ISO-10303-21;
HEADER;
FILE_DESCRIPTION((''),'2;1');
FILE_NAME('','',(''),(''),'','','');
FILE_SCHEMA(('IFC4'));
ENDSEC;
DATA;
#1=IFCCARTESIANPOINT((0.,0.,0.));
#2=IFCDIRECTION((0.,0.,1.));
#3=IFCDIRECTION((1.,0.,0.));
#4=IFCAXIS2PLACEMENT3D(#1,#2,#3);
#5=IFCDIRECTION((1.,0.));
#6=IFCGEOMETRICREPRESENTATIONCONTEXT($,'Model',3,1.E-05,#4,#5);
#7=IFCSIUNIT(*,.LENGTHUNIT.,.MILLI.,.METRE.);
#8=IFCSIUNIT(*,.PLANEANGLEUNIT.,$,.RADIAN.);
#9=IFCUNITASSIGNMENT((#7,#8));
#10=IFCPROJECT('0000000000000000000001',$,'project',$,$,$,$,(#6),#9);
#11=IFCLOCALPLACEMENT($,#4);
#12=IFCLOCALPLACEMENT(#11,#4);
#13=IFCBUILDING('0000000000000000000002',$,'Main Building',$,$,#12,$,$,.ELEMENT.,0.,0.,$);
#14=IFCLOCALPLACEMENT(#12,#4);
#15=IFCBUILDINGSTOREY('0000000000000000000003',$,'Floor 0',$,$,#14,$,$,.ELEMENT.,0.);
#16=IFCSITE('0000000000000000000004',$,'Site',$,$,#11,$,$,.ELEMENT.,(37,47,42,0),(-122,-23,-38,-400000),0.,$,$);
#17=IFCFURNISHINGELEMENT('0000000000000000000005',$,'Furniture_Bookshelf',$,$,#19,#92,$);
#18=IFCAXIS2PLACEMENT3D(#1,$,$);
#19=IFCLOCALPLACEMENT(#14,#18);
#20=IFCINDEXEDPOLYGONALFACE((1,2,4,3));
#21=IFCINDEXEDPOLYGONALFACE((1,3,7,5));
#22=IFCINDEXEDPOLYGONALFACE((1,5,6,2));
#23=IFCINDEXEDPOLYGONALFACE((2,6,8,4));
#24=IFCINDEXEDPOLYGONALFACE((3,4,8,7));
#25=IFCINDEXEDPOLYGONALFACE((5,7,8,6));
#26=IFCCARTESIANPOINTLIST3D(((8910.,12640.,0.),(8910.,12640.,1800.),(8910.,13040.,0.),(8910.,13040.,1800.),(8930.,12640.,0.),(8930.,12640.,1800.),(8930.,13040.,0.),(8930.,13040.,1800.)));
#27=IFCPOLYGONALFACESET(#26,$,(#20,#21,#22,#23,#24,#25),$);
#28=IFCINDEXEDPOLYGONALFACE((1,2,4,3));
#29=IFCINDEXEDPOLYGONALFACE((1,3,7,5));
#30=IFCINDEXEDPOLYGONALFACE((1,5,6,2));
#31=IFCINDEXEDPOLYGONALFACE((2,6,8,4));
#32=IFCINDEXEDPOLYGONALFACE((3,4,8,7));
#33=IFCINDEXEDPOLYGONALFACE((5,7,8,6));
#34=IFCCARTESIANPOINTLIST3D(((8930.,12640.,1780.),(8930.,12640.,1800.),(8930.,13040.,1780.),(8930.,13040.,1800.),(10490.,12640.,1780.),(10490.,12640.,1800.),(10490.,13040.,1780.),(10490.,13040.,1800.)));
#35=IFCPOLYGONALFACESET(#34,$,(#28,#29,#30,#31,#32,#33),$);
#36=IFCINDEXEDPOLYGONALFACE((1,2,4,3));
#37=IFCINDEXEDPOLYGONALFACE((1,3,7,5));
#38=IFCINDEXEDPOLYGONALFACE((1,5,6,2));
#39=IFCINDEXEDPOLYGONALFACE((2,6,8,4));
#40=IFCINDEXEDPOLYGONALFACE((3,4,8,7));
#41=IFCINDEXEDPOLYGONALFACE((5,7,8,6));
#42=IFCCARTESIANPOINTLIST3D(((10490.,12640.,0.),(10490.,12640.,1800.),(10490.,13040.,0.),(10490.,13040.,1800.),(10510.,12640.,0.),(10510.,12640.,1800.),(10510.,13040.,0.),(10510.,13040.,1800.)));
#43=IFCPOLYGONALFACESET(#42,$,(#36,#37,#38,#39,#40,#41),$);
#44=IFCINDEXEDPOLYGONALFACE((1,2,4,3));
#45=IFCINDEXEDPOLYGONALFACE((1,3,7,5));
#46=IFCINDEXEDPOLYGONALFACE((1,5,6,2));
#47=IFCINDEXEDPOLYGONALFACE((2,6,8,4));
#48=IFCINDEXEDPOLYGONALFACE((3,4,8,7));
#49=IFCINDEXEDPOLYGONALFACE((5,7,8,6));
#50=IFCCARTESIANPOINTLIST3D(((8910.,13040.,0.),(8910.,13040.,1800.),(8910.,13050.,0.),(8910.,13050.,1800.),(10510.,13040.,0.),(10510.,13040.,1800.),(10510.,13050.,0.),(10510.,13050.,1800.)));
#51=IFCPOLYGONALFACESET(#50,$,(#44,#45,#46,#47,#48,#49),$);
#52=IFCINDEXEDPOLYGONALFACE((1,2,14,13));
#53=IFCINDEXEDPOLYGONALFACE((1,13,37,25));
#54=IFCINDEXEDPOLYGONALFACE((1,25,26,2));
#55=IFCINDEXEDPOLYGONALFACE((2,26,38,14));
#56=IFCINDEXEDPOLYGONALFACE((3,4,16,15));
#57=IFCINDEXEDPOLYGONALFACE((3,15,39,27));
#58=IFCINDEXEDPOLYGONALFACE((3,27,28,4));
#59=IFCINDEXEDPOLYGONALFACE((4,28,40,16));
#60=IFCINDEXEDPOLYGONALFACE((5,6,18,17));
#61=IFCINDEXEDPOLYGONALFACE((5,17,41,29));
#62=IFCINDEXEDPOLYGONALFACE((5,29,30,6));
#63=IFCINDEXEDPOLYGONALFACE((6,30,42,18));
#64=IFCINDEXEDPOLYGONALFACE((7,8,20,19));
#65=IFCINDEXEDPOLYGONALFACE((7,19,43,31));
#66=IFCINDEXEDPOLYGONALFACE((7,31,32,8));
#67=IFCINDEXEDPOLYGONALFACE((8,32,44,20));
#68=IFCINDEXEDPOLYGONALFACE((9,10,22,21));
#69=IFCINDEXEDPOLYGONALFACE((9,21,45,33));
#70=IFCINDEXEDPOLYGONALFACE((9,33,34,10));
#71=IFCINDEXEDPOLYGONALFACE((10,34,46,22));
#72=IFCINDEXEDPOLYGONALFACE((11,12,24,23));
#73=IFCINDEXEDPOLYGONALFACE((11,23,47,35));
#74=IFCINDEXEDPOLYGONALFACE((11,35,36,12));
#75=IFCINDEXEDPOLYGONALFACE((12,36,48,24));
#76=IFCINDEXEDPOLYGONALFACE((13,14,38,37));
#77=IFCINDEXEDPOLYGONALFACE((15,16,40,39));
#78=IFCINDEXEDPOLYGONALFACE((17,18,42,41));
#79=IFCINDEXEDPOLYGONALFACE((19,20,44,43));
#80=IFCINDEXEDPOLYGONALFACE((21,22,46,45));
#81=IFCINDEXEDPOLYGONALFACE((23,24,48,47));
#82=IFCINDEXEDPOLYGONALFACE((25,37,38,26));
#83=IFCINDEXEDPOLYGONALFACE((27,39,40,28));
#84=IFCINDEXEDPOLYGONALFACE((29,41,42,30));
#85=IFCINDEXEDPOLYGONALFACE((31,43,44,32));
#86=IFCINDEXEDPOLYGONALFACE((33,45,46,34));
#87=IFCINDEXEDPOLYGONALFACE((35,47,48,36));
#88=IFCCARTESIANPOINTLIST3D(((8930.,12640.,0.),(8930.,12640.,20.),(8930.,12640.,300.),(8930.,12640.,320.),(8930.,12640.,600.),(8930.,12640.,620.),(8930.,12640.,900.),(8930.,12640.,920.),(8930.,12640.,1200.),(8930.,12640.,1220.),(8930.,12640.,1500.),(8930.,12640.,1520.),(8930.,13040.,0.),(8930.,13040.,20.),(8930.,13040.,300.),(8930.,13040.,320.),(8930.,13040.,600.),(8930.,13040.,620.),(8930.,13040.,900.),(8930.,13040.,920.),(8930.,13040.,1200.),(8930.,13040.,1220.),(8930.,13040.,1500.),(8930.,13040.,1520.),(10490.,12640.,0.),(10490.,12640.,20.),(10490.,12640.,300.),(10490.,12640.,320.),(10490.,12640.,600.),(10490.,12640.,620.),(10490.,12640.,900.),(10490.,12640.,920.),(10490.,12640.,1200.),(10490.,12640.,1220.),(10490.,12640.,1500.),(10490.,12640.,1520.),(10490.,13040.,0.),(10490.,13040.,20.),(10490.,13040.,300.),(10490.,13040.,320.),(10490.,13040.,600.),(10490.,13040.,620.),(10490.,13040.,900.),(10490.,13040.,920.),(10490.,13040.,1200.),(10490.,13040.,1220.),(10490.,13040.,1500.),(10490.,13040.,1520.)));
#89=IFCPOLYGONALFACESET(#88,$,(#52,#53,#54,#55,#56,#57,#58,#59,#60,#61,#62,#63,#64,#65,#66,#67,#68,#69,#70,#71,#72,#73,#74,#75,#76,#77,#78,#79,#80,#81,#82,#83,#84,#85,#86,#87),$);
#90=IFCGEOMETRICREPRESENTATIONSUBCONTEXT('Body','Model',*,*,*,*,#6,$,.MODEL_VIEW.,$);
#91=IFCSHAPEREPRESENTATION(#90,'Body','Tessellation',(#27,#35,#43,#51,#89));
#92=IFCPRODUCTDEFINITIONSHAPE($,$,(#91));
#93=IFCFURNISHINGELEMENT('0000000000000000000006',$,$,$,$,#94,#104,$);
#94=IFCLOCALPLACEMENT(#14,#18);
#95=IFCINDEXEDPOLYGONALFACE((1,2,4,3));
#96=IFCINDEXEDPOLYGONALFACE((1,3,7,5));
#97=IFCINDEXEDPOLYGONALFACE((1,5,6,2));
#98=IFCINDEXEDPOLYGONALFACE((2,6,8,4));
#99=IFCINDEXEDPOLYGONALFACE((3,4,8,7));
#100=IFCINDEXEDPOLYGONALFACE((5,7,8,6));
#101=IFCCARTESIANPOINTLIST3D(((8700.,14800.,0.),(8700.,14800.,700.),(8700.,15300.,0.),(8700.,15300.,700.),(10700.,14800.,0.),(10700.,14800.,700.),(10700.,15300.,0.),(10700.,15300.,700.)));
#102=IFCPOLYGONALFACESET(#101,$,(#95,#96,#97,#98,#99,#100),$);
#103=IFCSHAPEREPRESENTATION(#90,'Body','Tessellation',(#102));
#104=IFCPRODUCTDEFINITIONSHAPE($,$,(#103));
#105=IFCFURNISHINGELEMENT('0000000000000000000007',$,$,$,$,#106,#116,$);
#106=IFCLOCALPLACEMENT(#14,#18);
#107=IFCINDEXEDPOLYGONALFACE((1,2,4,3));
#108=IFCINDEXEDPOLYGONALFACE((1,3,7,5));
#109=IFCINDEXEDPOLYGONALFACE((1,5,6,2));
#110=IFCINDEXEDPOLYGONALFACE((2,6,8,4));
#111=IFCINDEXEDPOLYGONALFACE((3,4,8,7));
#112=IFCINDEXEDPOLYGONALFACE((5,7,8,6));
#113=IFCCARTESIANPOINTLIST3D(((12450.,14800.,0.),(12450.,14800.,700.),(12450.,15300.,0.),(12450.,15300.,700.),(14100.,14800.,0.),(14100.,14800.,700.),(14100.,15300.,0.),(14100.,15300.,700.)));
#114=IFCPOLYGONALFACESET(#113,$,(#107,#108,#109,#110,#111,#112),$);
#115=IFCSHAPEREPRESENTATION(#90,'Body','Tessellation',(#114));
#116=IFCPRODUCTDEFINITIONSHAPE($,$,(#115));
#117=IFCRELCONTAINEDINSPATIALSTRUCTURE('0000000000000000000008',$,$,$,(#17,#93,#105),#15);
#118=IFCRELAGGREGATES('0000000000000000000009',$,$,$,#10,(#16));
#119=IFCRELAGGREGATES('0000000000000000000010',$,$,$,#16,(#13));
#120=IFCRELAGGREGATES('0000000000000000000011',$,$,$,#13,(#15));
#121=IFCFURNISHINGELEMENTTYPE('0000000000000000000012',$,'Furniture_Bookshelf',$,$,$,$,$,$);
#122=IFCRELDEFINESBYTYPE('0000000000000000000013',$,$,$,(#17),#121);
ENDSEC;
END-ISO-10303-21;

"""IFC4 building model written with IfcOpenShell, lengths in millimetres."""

from ifc_helpers import new_model, si_unit, direction, frame, frame_2d, origin_with_axes, origin_2d_with_axis, place, context, subcontext, project, spatial, rectangle, extrude, source, transform, mapped, type_object, type_shapes, element, save


model = new_model("IFC4")

# Units and contexts
model_context = context("Model", 3, precision=1e-05, world=origin_with_axes(), true_north=direction((1.0, 0.0)))
body_context = subcontext(model_context, "Body", "Model", "MODEL_VIEW")
ifc_project = project(units=[si_unit("LENGTHUNIT", "METRE", prefix="MILLI"), si_unit("PLANEANGLEUNIT", "RADIAN")], contexts=[model_context])

# Site, building, storey
site_placement = place(None, origin_with_axes())
site = spatial("IfcSite", under=ifc_project, at=site_placement, Name="Site", CompositionType="ELEMENT", RefLatitude=(37, 47, 42, 0), RefLongitude=(-122, -23, -38, -400000), RefElevation=0.0)
building_placement = place(site_placement, origin_with_axes())
building = spatial("IfcBuilding", under=site, at=building_placement, Name="Main Building", CompositionType="ELEMENT", ElevationOfRefHeight=0.0, ElevationOfTerrain=0.0)
storey_placement = place(building_placement, origin_with_axes())
storey = spatial("IfcBuildingStorey", under=building, at=storey_placement, Name="Floor 0", CompositionType="ELEMENT", Elevation=0.0)

# Furnishing elements
furnishing_element_type_1 = type_object("IfcFurnishingElementType", Name="Furniture_Bookshelf")
shared_shape_1 = source(origin_with_axes(), body_context, "Body", "SweptSolid", [
    extrude(rectangle(XDim=400.0, YDim=20.0, at=frame_2d((0.0, 0.0), x_axis=(0.0, 1.0))), frame((10.0, 200.0, 0.0), z_axis=(0.0, 0.0, 1.0), x_axis=(1.0, 0.0, 0.0)), (0.0, 0.0, 1.0), 1800.0),
])
shared_shape_2 = source(origin_with_axes(), body_context, "Body", "SweptSolid", [
    extrude(rectangle(XDim=1560.0, YDim=400.0, at=origin_2d_with_axis()), frame((800.0, 200.0, 1780.0), z_axis=(0.0, 0.0, 1.0), x_axis=(1.0, 0.0, 0.0)), (0.0, 0.0, 1.0), 20.0),
])
shared_shape_3 = source(origin_with_axes(), body_context, "Body", "SweptSolid", [
    extrude(rectangle(XDim=400.0, YDim=20.0, at=frame_2d((0.0, 0.0), x_axis=(0.0, 1.0))), frame((1590.0, 200.0, 0.0), z_axis=(0.0, 0.0, 1.0), x_axis=(1.0, 0.0, 0.0)), (0.0, 0.0, 1.0), 1800.0),
])
shared_shape_4 = source(origin_with_axes(), body_context, "Body", "SweptSolid", [
    extrude(rectangle(XDim=1600.0, YDim=10.0, at=origin_2d_with_axis()), frame((800.0, 405.0, 0.0), z_axis=(0.0, 0.0, 1.0), x_axis=(1.0, 0.0, 0.0)), (0.0, 0.0, 1.0), 1800.0),
])
shared_shape_5 = source(origin_with_axes(), body_context, "Body", "SweptSolid", [
    extrude(rectangle(XDim=1560.0, YDim=400.0, at=origin_2d_with_axis()), frame((200.0, 50.0, -10.0), z_axis=(0.0, 0.0, 1.0), x_axis=(1.0, 0.0, 0.0)), (0.0, 0.0, 1.0), 20.0),
])
shared_shape_6 = source(origin_with_axes(), body_context, "Body", "MappedRepresentation", [
    mapped(shared_shape_5, transform((0.0, 0.0, 0.0), x_axis=(1.0, 0.0, 0.0), y_axis=(0.0, 1.0, 0.0), z_axis=(0.0, 0.0, 1.0), scale=1.0)),
    mapped(shared_shape_5, transform((0.0, 0.0, 300.0), x_axis=(1.0, 0.0, 0.0), y_axis=(0.0, 1.0, 0.0), z_axis=(0.0, 0.0, 1.0), scale=1.0)),
    mapped(shared_shape_5, transform((0.0, 0.0, 600.0), x_axis=(1.0, 0.0, 0.0), y_axis=(0.0, 1.0, 0.0), z_axis=(0.0, 0.0, 1.0), scale=1.0)),
    mapped(shared_shape_5, transform((0.0, 0.0, 900.0), x_axis=(1.0, 0.0, 0.0), y_axis=(0.0, 1.0, 0.0), z_axis=(0.0, 0.0, 1.0), scale=1.0)),
    mapped(shared_shape_5, transform((0.0, 0.0, 1200.0), x_axis=(1.0, 0.0, 0.0), y_axis=(0.0, 1.0, 0.0), z_axis=(0.0, 0.0, 1.0), scale=1.0)),
    mapped(shared_shape_5, transform((0.0, 0.0, 1500.0), x_axis=(1.0, 0.0, 0.0), y_axis=(0.0, 1.0, 0.0), z_axis=(0.0, 0.0, 1.0), scale=1.0)),
])
shared_shape_7 = source(origin_with_axes(), body_context, "Body", "MappedRepresentation", [
    mapped(shared_shape_1, transform((0.0, 0.0, 0.0), x_axis=(1.0, 0.0, 0.0), y_axis=(0.0, 1.0, 0.0), z_axis=(0.0, 0.0, 1.0), scale=1.0)),
    mapped(shared_shape_2, transform((0.0, 0.0, 0.0), x_axis=(1.0, 0.0, 0.0), y_axis=(0.0, 1.0, 0.0), z_axis=(0.0, 0.0, 1.0), scale=1.0)),
    mapped(shared_shape_3, transform((0.0, 0.0, 0.0), x_axis=(1.0, 0.0, 0.0), y_axis=(0.0, 1.0, 0.0), z_axis=(0.0, 0.0, 1.0), scale=1.0)),
    mapped(shared_shape_4, transform((0.0, 0.0, 0.0), x_axis=(1.0, 0.0, 0.0), y_axis=(0.0, 1.0, 0.0), z_axis=(0.0, 0.0, 1.0), scale=1.0)),
    mapped(shared_shape_6, transform((600.0, 150.0, 10.0), x_axis=(1.0, 0.0, 0.0), y_axis=(0.0, 1.0, 0.0), z_axis=(0.0, 0.0, 1.0), scale=1.0)),
])
type_shapes(furnishing_element_type_1, [shared_shape_7])
for number, where, z_axis, x_axis, name in (
    (1, (8910.0, 12640.0, 0.0), (0.0, 0.0, 1.0), (1.0, 0.0, 0.0), "Furniture_Bookshelf"),
):
    element("IfcFurnishingElement", number, at=place(storey_placement, frame(where, z_axis=z_axis, x_axis=x_axis)), inside=storey, type_object=furnishing_element_type_1, Name=name, context=body_context, shape_type="MappedRepresentation", body=[
        mapped(shared_shape_7, transform((0.0, 0.0, 0.0), x_axis=(1.0, 0.0, 0.0), y_axis=(0.0, 1.0, 0.0), z_axis=(0.0, 0.0, 1.0), scale=1.0)),
    ])
furnishing_1_placement = place(storey_placement, frame((8700.0, 14800.0, 0.0), z_axis=(0.0, 0.0, 1.0), x_axis=(1.0, 0.0, 0.0)))
element("IfcFurnishingElement", 2, at=furnishing_1_placement, inside=storey, context=body_context, shape_type="SweptSolid", body=[
    extrude(rectangle(XDim=2000.0, YDim=500.0, at=origin_2d_with_axis()), frame((1000.0, 250.0, 0.0), z_axis=(0.0, 0.0, 1.0), x_axis=(1.0, 0.0, 0.0)), (0.0, 0.0, 1.0), 700.0),
])
furnishing_2_placement = place(storey_placement, frame((12450.0, 14800.0, 0.0), z_axis=(0.0, 0.0, 1.0), x_axis=(1.0, 0.0, 0.0)))
element("IfcFurnishingElement", 3, at=furnishing_2_placement, inside=storey, context=body_context, shape_type="SweptSolid", body=[
    extrude(rectangle(XDim=1650.0, YDim=500.0, at=origin_2d_with_axis()), frame((825.0, 250.0, 0.0), z_axis=(0.0, 0.0, 1.0), x_axis=(1.0, 0.0, 0.0)), (0.0, 0.0, 1.0), 700.0),
])

save(model, "model.ifc")
